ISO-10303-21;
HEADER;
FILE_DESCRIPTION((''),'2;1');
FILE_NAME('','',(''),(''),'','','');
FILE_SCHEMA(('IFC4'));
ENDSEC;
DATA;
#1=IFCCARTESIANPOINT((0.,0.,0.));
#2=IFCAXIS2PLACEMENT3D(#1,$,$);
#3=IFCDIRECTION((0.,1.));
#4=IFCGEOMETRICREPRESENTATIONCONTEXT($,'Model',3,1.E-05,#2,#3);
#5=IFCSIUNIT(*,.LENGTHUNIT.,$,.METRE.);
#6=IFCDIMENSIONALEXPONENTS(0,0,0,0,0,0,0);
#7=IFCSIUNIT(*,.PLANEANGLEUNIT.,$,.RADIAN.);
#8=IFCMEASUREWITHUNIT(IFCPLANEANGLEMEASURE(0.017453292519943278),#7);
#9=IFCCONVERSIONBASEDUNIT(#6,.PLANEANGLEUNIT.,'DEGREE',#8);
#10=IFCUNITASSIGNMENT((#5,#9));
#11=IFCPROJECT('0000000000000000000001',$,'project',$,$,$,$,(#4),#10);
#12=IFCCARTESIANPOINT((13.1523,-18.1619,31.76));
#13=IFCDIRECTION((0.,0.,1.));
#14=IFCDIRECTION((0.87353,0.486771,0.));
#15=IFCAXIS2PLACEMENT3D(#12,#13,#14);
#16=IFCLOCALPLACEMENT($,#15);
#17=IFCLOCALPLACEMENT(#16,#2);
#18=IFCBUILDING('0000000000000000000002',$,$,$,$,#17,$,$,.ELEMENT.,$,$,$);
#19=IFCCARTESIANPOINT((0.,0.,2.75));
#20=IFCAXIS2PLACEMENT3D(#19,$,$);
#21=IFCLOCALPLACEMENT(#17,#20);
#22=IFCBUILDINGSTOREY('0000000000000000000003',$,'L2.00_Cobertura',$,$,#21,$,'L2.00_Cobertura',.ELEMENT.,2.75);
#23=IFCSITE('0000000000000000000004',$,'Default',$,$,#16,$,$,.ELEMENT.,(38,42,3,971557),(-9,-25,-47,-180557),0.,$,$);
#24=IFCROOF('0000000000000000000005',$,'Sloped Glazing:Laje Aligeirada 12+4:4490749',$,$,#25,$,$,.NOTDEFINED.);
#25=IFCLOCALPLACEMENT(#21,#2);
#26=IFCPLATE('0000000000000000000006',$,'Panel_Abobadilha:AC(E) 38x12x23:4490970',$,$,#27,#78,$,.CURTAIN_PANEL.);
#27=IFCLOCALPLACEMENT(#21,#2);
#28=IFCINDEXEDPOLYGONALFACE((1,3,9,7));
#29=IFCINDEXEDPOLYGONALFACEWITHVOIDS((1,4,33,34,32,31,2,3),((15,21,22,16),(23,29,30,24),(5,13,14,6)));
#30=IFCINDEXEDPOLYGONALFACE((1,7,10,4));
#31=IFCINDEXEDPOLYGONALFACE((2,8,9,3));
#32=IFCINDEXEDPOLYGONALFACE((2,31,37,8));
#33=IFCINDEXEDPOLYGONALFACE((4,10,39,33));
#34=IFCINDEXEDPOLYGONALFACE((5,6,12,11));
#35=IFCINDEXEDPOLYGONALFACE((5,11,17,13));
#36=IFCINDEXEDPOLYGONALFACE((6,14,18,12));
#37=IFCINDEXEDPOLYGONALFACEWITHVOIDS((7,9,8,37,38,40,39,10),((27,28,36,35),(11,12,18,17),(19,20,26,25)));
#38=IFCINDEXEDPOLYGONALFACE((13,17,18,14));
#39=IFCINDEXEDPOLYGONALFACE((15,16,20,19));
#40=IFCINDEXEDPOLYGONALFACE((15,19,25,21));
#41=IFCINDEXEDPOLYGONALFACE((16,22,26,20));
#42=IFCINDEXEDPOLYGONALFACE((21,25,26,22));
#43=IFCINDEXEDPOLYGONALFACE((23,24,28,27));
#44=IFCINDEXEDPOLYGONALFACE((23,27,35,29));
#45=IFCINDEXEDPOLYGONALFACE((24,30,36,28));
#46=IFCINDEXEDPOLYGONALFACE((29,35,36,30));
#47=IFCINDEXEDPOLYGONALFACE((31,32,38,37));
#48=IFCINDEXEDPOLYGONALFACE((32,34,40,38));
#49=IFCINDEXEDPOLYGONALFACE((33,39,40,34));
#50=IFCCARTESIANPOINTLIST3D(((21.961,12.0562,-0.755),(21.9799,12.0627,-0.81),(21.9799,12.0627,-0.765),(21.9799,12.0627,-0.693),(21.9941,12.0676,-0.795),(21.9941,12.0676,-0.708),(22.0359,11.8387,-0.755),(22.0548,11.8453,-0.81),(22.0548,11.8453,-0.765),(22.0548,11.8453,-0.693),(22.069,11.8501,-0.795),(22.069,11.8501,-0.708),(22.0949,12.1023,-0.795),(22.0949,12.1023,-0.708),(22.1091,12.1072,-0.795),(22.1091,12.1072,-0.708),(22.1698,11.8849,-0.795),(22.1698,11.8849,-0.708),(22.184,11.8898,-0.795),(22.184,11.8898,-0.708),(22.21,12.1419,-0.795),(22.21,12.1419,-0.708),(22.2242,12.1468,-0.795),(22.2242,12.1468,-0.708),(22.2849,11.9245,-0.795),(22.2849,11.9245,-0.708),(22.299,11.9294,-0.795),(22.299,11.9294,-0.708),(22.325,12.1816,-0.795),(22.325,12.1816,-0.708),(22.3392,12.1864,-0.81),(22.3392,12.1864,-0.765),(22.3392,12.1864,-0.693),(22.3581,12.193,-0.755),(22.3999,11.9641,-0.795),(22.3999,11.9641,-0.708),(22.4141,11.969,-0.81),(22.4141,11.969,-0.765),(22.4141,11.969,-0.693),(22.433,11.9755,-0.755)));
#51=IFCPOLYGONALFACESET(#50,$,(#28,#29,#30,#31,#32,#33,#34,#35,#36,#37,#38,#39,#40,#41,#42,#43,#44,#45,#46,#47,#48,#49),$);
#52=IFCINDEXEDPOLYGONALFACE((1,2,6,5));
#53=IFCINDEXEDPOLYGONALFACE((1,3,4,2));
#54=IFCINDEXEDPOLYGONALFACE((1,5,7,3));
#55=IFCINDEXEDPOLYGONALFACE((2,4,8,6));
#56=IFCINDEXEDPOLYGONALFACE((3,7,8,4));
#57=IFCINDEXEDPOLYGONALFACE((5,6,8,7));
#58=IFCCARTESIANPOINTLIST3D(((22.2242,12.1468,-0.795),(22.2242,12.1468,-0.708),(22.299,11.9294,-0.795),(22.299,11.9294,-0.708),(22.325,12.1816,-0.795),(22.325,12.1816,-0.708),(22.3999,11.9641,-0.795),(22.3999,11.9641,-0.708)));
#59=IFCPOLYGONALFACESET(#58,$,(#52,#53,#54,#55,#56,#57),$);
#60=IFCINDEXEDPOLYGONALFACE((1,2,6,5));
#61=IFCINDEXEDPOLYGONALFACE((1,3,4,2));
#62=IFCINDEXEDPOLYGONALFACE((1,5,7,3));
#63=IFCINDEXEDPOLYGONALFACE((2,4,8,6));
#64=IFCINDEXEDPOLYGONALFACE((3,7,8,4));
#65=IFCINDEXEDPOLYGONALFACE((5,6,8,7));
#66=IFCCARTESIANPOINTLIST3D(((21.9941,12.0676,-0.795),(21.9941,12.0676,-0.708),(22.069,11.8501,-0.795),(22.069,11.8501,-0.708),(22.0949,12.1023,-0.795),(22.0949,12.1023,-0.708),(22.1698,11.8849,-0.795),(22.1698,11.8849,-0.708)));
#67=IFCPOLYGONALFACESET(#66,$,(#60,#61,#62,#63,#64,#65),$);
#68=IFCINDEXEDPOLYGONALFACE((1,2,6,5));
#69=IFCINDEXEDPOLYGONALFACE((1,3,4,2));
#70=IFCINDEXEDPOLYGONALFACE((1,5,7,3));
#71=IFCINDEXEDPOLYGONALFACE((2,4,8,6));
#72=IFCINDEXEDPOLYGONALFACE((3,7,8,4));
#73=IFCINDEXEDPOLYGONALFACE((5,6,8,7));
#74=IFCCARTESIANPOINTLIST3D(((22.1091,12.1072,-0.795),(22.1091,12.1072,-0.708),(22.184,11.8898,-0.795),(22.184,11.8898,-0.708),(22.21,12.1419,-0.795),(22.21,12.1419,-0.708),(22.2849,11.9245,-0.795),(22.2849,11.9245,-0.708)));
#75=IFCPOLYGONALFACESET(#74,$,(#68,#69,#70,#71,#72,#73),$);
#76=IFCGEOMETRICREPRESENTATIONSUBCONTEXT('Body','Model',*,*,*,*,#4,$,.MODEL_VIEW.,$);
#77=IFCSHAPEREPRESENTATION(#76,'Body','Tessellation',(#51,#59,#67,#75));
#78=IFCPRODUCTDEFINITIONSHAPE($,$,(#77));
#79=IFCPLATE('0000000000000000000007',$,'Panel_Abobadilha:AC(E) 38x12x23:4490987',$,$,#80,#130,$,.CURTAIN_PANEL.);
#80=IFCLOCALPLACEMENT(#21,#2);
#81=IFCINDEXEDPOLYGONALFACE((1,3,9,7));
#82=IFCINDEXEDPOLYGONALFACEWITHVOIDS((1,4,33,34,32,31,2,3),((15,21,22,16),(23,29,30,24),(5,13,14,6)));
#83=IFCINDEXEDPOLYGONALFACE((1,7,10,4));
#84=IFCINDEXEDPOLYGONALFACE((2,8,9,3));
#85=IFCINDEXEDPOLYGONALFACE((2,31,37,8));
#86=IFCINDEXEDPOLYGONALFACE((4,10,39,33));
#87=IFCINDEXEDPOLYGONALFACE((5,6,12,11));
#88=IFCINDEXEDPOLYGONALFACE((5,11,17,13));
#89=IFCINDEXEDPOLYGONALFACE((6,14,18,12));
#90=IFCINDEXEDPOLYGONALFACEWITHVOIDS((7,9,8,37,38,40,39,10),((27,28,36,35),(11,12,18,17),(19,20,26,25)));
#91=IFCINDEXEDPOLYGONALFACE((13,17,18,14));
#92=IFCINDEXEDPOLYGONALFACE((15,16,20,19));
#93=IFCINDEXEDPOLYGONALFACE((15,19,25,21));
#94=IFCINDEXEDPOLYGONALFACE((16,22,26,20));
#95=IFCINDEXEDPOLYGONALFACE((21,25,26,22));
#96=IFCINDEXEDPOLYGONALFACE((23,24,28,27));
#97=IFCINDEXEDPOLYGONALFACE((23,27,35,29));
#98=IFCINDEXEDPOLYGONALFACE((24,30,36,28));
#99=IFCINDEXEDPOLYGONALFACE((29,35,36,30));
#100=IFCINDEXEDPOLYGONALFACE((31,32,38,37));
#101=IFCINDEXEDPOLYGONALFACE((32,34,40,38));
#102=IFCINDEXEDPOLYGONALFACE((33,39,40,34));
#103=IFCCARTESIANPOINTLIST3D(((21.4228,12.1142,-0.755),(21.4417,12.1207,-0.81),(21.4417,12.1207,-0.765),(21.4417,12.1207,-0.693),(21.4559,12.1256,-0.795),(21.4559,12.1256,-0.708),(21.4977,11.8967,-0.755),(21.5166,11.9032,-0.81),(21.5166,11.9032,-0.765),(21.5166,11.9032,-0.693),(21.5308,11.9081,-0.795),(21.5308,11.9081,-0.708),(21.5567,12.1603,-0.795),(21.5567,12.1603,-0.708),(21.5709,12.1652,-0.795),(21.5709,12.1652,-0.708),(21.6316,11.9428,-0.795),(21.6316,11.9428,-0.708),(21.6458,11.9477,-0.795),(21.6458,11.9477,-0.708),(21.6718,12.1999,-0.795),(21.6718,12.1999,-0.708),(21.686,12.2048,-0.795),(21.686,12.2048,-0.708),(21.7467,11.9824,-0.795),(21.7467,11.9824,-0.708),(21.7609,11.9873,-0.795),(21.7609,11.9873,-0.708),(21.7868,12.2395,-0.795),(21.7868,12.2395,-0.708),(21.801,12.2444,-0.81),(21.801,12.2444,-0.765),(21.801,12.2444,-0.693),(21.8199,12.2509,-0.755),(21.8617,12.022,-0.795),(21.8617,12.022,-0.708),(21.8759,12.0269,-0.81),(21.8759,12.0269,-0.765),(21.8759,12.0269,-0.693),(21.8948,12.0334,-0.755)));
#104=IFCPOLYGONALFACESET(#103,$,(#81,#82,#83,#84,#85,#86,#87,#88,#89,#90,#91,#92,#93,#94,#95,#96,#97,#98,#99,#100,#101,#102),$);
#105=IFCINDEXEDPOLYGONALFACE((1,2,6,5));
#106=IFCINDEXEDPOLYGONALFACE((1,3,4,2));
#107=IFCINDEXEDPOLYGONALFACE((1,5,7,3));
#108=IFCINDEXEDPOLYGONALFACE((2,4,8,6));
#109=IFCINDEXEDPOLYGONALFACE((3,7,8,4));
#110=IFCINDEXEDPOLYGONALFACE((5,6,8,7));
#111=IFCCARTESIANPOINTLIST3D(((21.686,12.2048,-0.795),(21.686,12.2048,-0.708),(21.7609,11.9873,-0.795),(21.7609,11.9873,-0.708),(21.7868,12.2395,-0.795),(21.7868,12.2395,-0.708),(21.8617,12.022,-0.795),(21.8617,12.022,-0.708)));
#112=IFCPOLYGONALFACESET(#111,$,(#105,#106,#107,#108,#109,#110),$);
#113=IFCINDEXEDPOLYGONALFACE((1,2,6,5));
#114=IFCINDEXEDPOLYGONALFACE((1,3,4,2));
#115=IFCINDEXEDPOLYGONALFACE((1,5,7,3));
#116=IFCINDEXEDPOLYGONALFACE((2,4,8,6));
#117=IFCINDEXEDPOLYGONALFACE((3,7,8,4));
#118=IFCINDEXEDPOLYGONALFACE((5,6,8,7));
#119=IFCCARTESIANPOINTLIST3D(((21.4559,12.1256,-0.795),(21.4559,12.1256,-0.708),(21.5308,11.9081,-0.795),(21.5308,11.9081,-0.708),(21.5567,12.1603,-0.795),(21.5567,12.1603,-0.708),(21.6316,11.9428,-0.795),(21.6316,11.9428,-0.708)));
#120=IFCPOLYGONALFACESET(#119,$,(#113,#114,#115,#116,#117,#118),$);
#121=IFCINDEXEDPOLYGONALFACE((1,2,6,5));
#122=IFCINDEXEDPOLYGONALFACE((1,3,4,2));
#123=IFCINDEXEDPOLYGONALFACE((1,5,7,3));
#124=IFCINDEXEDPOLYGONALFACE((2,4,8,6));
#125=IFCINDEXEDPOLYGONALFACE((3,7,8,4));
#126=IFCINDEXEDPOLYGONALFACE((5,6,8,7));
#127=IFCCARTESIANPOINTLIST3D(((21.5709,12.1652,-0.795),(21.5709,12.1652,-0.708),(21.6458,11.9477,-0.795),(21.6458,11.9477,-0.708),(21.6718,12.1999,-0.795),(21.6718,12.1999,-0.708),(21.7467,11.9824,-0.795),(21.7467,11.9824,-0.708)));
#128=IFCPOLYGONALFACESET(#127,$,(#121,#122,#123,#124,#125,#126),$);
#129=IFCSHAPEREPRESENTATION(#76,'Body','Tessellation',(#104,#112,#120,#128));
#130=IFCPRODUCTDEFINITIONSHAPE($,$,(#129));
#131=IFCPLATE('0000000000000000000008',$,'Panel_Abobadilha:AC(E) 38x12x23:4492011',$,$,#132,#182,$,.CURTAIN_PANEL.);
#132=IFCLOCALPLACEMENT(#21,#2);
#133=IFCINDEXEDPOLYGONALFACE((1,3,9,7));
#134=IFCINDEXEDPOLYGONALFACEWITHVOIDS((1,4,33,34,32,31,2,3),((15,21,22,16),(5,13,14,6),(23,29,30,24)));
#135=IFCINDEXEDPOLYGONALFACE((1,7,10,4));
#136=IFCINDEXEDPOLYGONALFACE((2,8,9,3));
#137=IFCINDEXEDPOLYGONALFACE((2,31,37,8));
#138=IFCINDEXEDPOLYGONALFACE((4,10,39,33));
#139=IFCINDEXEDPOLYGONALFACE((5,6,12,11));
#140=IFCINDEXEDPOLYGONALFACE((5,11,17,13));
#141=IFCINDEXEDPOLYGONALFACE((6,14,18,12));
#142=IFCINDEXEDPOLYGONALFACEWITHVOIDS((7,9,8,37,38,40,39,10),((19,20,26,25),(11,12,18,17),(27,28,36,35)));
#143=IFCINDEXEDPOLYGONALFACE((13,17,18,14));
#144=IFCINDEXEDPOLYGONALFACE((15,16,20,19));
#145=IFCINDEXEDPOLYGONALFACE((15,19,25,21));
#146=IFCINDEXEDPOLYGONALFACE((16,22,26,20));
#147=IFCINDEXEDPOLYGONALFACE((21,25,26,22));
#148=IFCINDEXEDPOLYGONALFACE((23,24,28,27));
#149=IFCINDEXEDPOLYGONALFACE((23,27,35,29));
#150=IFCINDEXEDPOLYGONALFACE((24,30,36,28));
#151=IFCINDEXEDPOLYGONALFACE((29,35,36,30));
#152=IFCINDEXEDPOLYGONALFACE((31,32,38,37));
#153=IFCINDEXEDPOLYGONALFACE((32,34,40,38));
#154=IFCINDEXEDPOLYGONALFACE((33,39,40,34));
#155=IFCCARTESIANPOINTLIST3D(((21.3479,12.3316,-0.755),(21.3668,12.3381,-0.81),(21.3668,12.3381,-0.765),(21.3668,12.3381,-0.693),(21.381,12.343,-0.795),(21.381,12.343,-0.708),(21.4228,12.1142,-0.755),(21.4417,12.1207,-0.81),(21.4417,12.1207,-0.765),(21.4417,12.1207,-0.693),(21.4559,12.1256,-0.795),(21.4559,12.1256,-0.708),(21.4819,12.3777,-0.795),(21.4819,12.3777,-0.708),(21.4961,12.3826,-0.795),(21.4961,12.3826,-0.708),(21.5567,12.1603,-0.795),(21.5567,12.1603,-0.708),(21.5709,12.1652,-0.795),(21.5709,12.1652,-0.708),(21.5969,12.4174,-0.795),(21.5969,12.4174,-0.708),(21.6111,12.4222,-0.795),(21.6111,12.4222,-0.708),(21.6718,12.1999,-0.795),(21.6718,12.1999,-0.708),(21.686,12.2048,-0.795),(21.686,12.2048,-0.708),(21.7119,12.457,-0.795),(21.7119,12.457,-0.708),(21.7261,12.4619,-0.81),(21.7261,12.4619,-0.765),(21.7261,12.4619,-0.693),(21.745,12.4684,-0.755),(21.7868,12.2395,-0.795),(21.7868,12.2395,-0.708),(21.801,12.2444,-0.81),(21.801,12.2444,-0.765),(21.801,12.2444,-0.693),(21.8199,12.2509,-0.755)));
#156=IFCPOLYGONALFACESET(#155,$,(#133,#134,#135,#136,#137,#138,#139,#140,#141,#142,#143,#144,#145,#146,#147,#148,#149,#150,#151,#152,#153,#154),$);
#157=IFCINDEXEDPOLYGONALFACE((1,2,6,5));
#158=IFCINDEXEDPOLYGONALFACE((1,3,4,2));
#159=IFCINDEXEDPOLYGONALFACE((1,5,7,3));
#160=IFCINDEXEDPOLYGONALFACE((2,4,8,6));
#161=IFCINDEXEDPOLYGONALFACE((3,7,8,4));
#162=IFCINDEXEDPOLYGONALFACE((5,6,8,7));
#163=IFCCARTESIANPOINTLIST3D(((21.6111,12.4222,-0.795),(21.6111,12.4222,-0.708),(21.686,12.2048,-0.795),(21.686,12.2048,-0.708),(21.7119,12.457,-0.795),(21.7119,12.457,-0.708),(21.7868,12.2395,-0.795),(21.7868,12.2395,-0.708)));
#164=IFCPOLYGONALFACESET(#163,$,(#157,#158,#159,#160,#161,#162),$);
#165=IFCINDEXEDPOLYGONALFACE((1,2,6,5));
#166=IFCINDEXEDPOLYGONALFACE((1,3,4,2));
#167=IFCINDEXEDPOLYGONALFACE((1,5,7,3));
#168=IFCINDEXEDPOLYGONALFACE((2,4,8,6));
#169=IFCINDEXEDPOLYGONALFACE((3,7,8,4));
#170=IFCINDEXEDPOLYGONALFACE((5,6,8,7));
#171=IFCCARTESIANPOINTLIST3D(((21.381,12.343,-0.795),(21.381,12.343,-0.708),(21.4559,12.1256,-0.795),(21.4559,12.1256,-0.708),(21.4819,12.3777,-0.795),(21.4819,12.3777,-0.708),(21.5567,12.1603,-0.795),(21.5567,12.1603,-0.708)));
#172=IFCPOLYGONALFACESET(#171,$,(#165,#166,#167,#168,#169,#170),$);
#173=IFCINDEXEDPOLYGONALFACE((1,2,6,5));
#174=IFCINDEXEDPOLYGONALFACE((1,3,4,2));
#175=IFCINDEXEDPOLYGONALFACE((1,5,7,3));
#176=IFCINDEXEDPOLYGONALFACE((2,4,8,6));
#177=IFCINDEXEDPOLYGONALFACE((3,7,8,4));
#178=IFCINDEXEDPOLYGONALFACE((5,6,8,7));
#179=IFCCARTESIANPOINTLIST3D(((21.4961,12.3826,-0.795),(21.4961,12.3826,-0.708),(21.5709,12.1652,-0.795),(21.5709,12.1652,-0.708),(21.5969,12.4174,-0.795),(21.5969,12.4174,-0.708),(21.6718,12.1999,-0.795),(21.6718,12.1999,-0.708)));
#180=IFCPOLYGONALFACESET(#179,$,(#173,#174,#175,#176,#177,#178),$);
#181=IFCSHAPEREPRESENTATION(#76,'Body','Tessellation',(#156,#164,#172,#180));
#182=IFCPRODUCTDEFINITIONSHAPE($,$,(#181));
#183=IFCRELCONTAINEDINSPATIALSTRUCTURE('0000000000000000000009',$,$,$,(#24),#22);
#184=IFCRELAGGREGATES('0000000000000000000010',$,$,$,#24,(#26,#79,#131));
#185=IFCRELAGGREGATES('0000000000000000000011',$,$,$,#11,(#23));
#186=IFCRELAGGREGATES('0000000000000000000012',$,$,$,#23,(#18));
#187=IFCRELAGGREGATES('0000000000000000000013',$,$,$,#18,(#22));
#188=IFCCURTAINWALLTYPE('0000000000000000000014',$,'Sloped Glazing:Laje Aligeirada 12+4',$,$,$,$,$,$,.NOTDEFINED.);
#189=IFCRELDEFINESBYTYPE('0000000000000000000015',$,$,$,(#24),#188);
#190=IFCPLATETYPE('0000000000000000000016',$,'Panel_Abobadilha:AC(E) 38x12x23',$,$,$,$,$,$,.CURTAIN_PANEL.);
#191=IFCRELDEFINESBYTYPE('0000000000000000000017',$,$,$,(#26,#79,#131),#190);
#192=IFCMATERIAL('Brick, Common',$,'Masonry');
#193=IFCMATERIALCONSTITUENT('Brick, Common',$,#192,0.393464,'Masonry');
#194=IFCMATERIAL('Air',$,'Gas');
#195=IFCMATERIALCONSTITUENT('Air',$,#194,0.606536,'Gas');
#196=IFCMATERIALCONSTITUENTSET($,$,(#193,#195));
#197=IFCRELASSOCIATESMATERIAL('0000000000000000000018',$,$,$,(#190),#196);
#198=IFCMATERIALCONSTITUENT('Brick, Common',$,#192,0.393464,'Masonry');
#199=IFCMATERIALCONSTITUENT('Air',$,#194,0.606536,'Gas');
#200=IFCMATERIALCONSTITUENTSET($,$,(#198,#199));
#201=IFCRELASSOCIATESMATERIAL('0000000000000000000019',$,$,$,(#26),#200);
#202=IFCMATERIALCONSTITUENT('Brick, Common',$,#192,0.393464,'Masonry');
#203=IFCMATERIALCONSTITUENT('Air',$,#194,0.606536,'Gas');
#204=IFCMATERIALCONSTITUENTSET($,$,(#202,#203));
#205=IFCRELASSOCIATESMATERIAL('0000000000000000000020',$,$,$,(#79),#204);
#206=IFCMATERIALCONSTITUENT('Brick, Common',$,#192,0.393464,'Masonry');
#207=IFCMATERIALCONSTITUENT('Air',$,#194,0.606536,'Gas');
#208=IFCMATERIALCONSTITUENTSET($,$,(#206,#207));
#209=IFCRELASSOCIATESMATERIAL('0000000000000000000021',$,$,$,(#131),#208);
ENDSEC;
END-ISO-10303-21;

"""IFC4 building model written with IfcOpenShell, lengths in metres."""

from ifc_helpers import new_model, entity, si_unit, converted_unit, direction, frame, origin, place, context, subcontext, project, spatial, indexed_curve, outline, extrude, source, transform, mapped, material, constituent, constituent_set, type_object, type_shapes, element, aggregate, save


model = new_model("IFC4")

# Units and contexts
model_context = context("Model", 3, precision=1e-05, world=origin(), true_north=direction((0.0, 1.0)))
body_context = subcontext(model_context, "Body", "Model", "MODEL_VIEW")
ifc_project = project(units=[si_unit("LENGTHUNIT", "METRE"), converted_unit("PLANEANGLEUNIT", "DEGREE", entity("IfcPlaneAngleMeasure", 0.017453292519943278), si_unit("PLANEANGLEUNIT", "RADIAN"), dimensions=[0, 0, 0, 0, 0, 0, 0])], contexts=[model_context])

# Site, building, storey
site_placement = place(None, frame((13.1523, -18.1619, 31.76), z_axis=(0.0, 0.0, 1.0), x_axis=(0.87353, 0.486771, 0.0)))
site = spatial("IfcSite", under=ifc_project, at=site_placement, Name="Default", CompositionType="ELEMENT", RefLatitude=(38, 42, 3, 971557), RefLongitude=(-9, -25, -47, -180557), RefElevation=0.0)
building_placement = place(site_placement, origin())
building = spatial("IfcBuilding", under=site, at=building_placement, CompositionType="ELEMENT")
storey_placement = place(building_placement, frame((0.0, 0.0, 2.75)))
storey = spatial("IfcBuildingStorey", under=building, at=storey_placement, Name="L2.00_Cobertura", LongName="L2.00_Cobertura", CompositionType="ELEMENT", Elevation=2.75)

# Roof, plates
curtain_wall_type = type_object("IfcCurtainWallType", Name="Sloped Glazing:Laje Aligeirada 12+4", PredefinedType="NOTDEFINED")
roof_placement = place(storey_placement, frame((0.0, 0.0, -2.75)))
roof = element("IfcRoof", 1, at=roof_placement, inside=storey, type_object=curtain_wall_type, Name="Sloped Glazing:Laje Aligeirada 12+4:4490749", PredefinedType="NOTDEFINED")
ifc_material_1 = material(Name="Brick, Common", Category="Masonry")
ifc_material_2 = material(Name="Air", Category="Gas")
ifc_constituent_1 = constituent(ifc_material_1, Name="Brick, Common", Category="Masonry", fraction=0.393464)
ifc_constituent_2 = constituent(ifc_material_2, Name="Air", Category="Gas", fraction=0.606536)
ifc_constituent_set_1 = constituent_set(constituents=[ifc_constituent_1, ifc_constituent_2])
plate_type_1 = type_object("IfcPlateType", Name="Panel_Abobadilha:AC(E) 38x12x23", PredefinedType="CURTAIN_PANEL", material=ifc_constituent_set_1)
shared_shape_1 = source(origin(), body_context, "Body", "SweptSolid", [
    extrude(outline(indexed_curve([(-0.19, -0.0543), (0.19, -0.0543), (0.19, -0.0093), (0.21, 0.0007), (0.19, 0.0628), (-0.19, 0.0628), (-0.21, 0.0007), (-0.19, -0.0093), (-0.19, -0.0543)], self_intersect=False), holes=[indexed_curve([(-0.0683, 0.0477), (-0.0683, -0.0393), (-0.175, -0.0393), (-0.175, 0.0477), (-0.0683, 0.0477)], self_intersect=False), indexed_curve([(0.0533, 0.0477), (0.0533, -0.0393), (-0.0533, -0.0393), (-0.0533, 0.0477), (0.0533, 0.0477)], self_intersect=False), indexed_curve([(0.175, 0.0477), (0.175, -0.0393), (0.0683, -0.0393), (0.0683, 0.0477), (0.175, 0.0477)], self_intersect=False)]), frame((0.0, 0.0543, 0.0)), (0.0, 0.0, 1.0), 0.23),
    extrude(outline(indexed_curve([(-0.0533, -0.0435), (0.0533, -0.0435), (0.0533, 0.0435), (-0.0533, 0.0435), (-0.0533, -0.0435)], self_intersect=False)), frame((0.1217, 0.0585, 0.0), z_axis=(0.0, 0.0, 1.0), x_axis=(-1.0, 0.0, 0.0)), (0.0, 0.0, 1.0), 0.23),
    extrude(outline(indexed_curve([(-0.0533, -0.0435), (0.0533, -0.0435), (0.0533, 0.0435), (-0.0533, 0.0435), (-0.0533, -0.0435)], self_intersect=False)), frame((-0.1217, 0.0585, 0.0), z_axis=(0.0, 0.0, 1.0), x_axis=(-1.0, 0.0, 0.0)), (0.0, 0.0, 1.0), 0.23),
    extrude(outline(indexed_curve([(-0.0533, -0.0435), (0.0533, -0.0435), (0.0533, 0.0435), (-0.0533, 0.0435), (-0.0533, -0.0435)], self_intersect=False)), frame((0.0, 0.0585, 0.0), z_axis=(0.0, 0.0, 1.0), x_axis=(-1.0, 0.0, 0.0)), (0.0, 0.0, 1.0), 0.23),
])
type_shapes(plate_type_1, [shared_shape_1])
ifc_constituent_3 = constituent(ifc_material_1, Name="Brick, Common", Category="Masonry", fraction=0.393464)
ifc_constituent_4 = constituent(ifc_material_2, Name="Air", Category="Gas", fraction=0.606536)
ifc_constituent_set_2 = constituent_set(constituents=[ifc_constituent_3, ifc_constituent_4])
plate_1_placement = place(roof_placement, frame((22.1595, 12.1246, 1.94), z_axis=(0.325568, -0.945519, 0.0), x_axis=(0.945519, 0.325568, 0.0)))
plate_1 = element("IfcPlate", 2, at=plate_1_placement, type_object=plate_type_1, material=ifc_constituent_set_2, Name="Panel_Abobadilha:AC(E) 38x12x23:4490970", PredefinedType="CURTAIN_PANEL", context=body_context, shape_type="MappedRepresentation", body=[
    mapped(shared_shape_1, transform((0.0, 0.0, 0.0), scale=1.0)),
])
ifc_constituent_5 = constituent(ifc_material_1, Name="Brick, Common", Category="Masonry", fraction=0.393464)
ifc_constituent_6 = constituent(ifc_material_2, Name="Air", Category="Gas", fraction=0.606536)
ifc_constituent_set_3 = constituent_set(constituents=[ifc_constituent_5, ifc_constituent_6])
plate_2_placement = place(roof_placement, frame((21.6214, 12.1825, 1.94), z_axis=(0.325568, -0.945519, 0.0), x_axis=(0.945519, 0.325568, 0.0)))
plate_2 = element("IfcPlate", 3, at=plate_2_placement, type_object=plate_type_1, material=ifc_constituent_set_3, Name="Panel_Abobadilha:AC(E) 38x12x23:4490987", PredefinedType="CURTAIN_PANEL", context=body_context, shape_type="MappedRepresentation", body=[
    mapped(shared_shape_1, transform((0.0, 0.0, 0.0), scale=1.0)),
])
ifc_constituent_7 = constituent(ifc_material_1, Name="Brick, Common", Category="Masonry", fraction=0.393464)
ifc_constituent_8 = constituent(ifc_material_2, Name="Air", Category="Gas", fraction=0.606536)
ifc_constituent_set_4 = constituent_set(constituents=[ifc_constituent_7, ifc_constituent_8])
plate_3_placement = place(roof_placement, frame((21.5465, 12.4, 1.94), z_axis=(0.325568, -0.945519, 0.0), x_axis=(0.945519, 0.325568, 0.0)))
plate_3 = element("IfcPlate", 4, at=plate_3_placement, type_object=plate_type_1, material=ifc_constituent_set_4, Name="Panel_Abobadilha:AC(E) 38x12x23:4492011", PredefinedType="CURTAIN_PANEL", context=body_context, shape_type="MappedRepresentation", body=[
    mapped(shared_shape_1, transform((0.0, 0.0, 0.0), scale=1.0)),
])
aggregate(roof, [plate_1, plate_2, plate_3])

save(model, "model.ifc")
